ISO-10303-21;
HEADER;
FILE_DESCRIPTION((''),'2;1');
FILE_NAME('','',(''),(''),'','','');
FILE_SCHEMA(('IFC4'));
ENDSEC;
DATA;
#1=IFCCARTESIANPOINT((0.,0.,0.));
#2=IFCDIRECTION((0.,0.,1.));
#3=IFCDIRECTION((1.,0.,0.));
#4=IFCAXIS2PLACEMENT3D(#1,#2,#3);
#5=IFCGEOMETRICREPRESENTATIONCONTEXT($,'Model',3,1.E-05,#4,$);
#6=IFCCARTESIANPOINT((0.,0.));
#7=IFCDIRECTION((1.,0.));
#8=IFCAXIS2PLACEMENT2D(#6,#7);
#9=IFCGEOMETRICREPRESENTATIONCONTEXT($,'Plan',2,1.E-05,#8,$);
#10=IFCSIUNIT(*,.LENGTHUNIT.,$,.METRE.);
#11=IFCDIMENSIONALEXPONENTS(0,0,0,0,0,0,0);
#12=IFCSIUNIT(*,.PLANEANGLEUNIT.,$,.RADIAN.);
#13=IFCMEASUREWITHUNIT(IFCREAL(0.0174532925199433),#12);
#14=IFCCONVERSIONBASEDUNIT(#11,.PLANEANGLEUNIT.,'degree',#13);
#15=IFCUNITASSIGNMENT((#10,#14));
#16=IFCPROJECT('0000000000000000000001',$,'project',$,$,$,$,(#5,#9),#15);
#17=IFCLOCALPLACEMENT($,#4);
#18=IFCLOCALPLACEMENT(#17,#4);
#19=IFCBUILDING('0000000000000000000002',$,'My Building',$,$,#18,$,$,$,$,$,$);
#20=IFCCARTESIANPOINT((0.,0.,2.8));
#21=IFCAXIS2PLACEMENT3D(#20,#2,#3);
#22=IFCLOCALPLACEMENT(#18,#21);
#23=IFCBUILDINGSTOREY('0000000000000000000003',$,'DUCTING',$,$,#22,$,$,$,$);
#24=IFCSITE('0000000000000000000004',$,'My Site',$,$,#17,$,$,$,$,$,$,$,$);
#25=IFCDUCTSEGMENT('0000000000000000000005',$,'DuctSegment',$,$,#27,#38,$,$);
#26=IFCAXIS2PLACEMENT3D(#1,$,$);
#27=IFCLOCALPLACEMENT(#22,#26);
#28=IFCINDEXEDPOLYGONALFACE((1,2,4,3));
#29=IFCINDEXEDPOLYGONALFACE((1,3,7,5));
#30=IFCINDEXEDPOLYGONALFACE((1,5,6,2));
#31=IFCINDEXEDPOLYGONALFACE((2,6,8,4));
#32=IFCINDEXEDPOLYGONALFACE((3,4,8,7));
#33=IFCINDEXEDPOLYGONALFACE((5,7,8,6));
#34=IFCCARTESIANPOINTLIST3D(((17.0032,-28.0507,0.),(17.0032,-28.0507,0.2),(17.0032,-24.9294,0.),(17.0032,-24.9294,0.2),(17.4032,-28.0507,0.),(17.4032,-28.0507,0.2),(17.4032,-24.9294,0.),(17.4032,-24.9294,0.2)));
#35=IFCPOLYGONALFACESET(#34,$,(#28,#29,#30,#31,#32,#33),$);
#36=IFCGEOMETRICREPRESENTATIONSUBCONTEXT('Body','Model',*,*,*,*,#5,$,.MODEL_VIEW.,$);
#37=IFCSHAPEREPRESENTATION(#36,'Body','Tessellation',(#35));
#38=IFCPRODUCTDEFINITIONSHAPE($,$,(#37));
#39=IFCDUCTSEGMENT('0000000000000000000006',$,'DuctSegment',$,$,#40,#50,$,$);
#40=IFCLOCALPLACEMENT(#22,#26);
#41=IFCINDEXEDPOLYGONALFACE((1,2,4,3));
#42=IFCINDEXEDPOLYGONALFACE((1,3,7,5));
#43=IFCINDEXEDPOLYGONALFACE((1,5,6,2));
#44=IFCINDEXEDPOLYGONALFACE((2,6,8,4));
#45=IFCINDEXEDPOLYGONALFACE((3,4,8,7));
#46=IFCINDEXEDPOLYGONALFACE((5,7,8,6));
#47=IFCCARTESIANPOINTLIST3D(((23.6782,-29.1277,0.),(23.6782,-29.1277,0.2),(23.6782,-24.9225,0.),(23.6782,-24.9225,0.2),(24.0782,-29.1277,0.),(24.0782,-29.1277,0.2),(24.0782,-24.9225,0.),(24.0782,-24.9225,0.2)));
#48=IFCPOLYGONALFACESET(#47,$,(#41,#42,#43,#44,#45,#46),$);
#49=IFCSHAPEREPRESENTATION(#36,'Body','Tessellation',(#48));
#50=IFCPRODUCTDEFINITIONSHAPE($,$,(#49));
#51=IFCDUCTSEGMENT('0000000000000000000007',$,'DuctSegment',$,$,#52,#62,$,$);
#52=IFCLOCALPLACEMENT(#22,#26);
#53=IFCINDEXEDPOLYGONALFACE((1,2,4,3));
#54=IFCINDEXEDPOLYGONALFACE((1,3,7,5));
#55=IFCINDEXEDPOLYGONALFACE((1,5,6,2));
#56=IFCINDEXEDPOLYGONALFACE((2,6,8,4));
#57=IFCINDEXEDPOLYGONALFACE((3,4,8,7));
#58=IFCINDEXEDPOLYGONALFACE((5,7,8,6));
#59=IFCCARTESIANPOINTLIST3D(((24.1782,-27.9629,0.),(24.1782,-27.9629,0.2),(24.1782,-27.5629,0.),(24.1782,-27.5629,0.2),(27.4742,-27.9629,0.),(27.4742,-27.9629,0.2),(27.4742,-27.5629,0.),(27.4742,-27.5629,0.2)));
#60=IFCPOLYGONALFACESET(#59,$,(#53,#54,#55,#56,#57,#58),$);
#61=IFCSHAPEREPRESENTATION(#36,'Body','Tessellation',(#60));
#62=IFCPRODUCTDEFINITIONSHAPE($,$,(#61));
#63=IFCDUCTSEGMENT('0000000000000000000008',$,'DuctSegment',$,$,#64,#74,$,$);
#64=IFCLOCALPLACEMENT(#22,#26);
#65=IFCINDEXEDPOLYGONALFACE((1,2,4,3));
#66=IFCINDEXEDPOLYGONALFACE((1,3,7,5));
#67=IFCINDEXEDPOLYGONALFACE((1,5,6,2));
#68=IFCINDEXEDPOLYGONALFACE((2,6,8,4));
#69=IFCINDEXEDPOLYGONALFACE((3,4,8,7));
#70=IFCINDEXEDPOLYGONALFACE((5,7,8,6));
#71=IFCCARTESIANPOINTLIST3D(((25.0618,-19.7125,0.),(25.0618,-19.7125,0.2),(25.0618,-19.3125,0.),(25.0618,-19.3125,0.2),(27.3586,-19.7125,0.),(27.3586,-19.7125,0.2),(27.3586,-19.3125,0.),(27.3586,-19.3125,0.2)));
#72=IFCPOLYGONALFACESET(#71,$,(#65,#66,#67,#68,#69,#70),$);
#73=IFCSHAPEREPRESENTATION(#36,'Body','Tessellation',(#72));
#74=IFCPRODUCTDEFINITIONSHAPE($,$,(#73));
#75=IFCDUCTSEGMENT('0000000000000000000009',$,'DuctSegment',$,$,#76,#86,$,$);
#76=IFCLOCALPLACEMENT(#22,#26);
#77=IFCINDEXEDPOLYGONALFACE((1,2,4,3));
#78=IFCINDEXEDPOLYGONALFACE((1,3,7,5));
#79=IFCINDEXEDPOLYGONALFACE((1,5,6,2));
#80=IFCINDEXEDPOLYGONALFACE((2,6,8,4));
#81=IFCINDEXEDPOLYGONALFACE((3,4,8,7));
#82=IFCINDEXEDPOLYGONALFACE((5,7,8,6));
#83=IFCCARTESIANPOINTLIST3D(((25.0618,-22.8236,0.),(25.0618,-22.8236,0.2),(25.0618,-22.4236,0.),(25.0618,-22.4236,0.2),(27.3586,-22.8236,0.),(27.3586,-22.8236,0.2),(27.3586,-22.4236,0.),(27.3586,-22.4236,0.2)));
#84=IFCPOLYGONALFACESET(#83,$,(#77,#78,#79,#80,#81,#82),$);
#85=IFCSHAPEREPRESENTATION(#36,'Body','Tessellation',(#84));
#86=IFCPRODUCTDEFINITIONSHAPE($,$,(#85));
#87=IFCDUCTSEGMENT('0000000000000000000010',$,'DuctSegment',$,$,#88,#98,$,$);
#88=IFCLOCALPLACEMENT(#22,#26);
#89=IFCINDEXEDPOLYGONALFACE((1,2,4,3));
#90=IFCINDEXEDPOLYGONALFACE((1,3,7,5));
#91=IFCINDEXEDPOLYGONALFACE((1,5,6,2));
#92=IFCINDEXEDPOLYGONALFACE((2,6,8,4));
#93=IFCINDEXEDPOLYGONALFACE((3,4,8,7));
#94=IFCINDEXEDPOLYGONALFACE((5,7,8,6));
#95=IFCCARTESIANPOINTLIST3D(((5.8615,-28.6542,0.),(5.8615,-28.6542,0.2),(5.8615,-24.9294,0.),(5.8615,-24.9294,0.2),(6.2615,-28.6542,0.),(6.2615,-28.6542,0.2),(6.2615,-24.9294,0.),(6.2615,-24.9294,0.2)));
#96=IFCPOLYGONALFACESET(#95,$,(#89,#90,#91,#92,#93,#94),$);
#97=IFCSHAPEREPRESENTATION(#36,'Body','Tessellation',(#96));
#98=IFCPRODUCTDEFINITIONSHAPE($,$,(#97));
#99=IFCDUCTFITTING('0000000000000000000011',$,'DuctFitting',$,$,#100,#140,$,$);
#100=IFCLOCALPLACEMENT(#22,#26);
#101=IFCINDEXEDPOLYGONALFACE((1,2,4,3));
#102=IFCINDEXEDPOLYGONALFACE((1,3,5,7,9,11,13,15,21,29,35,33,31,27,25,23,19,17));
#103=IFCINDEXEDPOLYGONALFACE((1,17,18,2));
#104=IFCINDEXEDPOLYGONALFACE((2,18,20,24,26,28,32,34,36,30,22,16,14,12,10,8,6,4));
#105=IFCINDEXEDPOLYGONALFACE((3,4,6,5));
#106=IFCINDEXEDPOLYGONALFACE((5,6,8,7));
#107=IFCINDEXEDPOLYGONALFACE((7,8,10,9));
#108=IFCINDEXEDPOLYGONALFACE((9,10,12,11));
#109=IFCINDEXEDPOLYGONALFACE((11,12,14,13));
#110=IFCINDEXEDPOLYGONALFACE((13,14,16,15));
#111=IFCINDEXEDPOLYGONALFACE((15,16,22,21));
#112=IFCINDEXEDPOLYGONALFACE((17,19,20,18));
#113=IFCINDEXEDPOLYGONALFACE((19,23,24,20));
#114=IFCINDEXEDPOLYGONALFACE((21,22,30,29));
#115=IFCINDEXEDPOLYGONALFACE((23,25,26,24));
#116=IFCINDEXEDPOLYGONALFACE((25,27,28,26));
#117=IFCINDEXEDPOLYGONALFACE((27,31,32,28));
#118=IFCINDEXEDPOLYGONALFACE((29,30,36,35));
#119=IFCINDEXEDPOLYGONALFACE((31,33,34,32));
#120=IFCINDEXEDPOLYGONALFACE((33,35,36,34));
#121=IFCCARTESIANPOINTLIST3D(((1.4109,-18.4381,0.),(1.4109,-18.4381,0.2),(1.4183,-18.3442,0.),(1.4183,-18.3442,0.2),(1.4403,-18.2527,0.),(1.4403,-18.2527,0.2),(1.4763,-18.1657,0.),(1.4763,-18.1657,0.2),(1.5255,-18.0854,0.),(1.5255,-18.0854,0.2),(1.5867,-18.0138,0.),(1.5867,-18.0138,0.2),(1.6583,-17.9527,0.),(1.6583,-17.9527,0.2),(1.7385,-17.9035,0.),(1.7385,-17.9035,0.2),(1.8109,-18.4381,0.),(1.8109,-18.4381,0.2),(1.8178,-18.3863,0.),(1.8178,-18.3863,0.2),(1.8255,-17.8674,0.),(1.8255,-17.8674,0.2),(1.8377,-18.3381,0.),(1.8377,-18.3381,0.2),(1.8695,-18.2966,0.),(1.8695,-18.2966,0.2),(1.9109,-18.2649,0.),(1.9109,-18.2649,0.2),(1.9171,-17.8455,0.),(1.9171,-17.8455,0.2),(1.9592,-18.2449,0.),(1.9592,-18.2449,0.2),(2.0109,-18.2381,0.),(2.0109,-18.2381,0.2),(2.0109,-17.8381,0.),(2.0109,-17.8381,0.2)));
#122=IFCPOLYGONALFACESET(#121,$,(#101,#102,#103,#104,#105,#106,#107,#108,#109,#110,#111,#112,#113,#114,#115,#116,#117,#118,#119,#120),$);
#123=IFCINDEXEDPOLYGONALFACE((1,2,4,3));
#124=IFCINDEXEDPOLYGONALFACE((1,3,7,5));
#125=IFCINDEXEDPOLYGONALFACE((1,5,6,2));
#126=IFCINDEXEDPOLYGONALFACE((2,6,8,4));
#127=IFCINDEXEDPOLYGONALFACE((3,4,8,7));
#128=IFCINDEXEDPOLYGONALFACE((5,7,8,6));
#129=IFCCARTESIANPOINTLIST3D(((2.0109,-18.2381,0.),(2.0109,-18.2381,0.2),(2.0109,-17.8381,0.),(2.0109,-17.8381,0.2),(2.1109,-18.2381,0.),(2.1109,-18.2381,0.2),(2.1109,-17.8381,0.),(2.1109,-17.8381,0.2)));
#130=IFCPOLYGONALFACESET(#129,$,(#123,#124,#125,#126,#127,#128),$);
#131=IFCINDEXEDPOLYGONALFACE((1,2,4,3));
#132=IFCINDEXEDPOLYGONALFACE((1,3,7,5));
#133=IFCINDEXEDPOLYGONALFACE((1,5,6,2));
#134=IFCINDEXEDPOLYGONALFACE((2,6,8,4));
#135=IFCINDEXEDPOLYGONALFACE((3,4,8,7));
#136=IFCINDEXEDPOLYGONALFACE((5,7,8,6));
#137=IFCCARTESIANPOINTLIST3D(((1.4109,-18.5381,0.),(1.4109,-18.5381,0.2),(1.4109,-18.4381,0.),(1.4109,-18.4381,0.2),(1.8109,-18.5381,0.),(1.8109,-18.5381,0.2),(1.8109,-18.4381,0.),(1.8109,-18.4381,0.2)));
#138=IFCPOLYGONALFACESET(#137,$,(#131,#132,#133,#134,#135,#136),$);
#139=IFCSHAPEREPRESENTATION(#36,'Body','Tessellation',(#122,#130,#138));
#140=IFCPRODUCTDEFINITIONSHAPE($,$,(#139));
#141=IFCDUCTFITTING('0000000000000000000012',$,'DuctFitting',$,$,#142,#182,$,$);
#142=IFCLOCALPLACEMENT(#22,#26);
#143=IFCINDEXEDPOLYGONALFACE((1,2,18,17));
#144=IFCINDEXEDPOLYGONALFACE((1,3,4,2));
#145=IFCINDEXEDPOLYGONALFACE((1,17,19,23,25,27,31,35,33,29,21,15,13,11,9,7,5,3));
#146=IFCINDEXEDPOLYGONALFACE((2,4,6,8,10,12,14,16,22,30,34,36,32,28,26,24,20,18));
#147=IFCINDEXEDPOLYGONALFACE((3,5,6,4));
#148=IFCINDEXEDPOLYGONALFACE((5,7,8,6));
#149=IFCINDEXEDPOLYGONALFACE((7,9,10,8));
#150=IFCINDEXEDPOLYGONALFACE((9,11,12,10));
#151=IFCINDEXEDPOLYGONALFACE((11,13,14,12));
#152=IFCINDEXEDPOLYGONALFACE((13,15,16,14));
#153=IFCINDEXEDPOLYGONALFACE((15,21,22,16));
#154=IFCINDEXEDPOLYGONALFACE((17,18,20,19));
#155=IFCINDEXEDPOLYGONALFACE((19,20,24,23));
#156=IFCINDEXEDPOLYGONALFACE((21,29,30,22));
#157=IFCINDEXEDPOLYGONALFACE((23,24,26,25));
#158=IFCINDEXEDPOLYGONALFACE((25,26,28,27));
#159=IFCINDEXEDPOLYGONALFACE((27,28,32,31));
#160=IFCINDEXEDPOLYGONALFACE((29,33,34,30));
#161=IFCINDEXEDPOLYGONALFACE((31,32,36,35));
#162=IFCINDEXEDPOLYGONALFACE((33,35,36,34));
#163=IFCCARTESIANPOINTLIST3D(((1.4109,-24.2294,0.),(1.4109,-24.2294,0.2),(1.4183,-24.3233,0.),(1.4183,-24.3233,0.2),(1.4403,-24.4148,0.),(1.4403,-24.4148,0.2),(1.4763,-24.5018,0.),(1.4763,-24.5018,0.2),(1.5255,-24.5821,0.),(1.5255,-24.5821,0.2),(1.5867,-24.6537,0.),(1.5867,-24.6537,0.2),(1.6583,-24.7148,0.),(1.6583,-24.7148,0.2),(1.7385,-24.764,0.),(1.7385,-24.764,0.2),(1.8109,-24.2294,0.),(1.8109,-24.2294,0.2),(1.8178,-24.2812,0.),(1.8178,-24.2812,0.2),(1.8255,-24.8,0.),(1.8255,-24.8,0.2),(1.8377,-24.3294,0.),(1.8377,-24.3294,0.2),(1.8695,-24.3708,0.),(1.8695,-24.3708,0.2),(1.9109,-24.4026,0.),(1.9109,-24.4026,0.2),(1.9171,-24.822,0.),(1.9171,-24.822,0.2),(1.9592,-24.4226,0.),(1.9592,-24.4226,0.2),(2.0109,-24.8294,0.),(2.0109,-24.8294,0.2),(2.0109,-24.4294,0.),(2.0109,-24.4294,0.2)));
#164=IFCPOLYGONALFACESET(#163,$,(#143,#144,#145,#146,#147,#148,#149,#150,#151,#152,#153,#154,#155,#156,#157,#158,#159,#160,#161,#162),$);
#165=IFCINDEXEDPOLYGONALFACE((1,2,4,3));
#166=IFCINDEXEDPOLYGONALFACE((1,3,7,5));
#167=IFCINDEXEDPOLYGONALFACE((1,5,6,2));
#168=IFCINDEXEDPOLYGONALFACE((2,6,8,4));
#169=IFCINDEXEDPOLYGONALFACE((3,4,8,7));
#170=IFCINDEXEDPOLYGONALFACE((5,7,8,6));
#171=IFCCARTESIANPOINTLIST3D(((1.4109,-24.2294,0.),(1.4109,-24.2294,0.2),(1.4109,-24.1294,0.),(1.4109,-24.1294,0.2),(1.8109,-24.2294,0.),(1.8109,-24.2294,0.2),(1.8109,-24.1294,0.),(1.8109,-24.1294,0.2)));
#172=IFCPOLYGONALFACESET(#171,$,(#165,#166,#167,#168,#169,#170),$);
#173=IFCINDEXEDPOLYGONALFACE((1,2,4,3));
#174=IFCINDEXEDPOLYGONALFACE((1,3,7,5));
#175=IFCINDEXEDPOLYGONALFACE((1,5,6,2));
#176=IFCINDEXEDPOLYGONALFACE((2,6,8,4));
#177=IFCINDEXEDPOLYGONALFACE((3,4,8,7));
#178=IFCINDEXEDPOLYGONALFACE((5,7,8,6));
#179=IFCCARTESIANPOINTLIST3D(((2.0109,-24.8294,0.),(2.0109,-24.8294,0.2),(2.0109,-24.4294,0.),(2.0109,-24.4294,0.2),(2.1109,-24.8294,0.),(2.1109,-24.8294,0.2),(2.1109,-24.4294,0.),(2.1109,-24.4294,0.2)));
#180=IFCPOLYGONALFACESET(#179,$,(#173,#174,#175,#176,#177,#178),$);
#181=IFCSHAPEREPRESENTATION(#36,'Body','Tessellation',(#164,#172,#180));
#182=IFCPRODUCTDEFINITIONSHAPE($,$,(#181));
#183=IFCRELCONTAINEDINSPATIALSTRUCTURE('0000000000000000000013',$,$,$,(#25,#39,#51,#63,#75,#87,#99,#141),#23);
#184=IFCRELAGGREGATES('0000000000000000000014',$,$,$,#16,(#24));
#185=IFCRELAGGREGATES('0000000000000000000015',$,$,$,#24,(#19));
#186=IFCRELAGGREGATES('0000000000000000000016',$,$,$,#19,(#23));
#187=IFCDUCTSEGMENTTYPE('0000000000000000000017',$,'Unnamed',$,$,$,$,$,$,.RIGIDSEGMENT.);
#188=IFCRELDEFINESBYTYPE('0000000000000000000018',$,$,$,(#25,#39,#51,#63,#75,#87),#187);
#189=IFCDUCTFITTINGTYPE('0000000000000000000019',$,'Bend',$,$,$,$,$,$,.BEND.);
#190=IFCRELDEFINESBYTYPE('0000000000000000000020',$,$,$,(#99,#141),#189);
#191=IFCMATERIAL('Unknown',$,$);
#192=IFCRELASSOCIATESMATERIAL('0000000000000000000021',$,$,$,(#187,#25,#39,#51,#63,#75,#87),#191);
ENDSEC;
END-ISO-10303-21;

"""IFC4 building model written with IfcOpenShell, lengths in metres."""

from ifc_helpers import new_model, entity, si_unit, converted_unit, frame, origin_with_axes, origin_2d_with_axis, place, context, subcontext, project, spatial, line, arc, indexed_curve, rectangle, outline, extrude, source, transform, mapped, material, material_profile, profile_set, profile_usage, type_object, type_shapes, element, save


model = new_model("IFC4")

# Units and contexts
model_context = context("Model", 3, precision=1e-05, world=origin_with_axes())
plan_context = context("Plan", 2, precision=1e-05, world=origin_2d_with_axis())
body_context = subcontext(model_context, "Body", "Model", "MODEL_VIEW")
ifc_project = project(units=[si_unit("LENGTHUNIT", "METRE"), converted_unit("PLANEANGLEUNIT", "degree", entity("IfcReal", 0.0174532925199433), si_unit("PLANEANGLEUNIT", "RADIAN"), dimensions=[0, 0, 0, 0, 0, 0, 0])], contexts=[model_context, plan_context])

# Site, building, storey
site_placement = place(None, origin_with_axes())
site = spatial("IfcSite", under=ifc_project, at=site_placement, Name="My Site")
building_placement = place(site_placement, origin_with_axes())
building = spatial("IfcBuilding", under=site, at=building_placement, Name="My Building")
storey_placement = place(building_placement, frame((0.0, 0.0, 2.8), z_axis=(0.0, 0.0, 1.0), x_axis=(1.0, 0.0, 0.0)))
storey = spatial("IfcBuildingStorey", under=building, at=storey_placement, Name="DUCTING")

# Duct segments
ifc_material = material(Name="Unknown")
ifc_material_profile_1 = material_profile(ifc_material, rectangle(XDim=0.4, YDim=0.2))
ifc_profile_set_1 = profile_set([ifc_material_profile_1])
duct_segment_type = type_object("IfcDuctSegmentType", Name="Unnamed", PredefinedType="RIGIDSEGMENT", material=ifc_profile_set_1)
ifc_profile_usage_1 = profile_usage(ifc_profile_set_1, cardinal=5)
duct_segment_1_placement = place(storey_placement, frame((17.2032, -24.9294, 0.1), z_axis=(0.0, -1.0, 0.0), x_axis=(1.0, 0.0, 0.0)))
element("IfcDuctSegment", 1, at=duct_segment_1_placement, inside=storey, type_object=duct_segment_type, material=ifc_profile_usage_1, Name="DuctSegment", context=body_context, shape_type="SweptSolid", body=[
    extrude(rectangle(XDim=0.4, YDim=0.2), origin_with_axes(), (0.0, 0.0, 1.0), 3.1213),
])
ifc_profile_usage_2 = profile_usage(ifc_profile_set_1, cardinal=5)
duct_segment_2_placement = place(storey_placement, frame((23.8782, -24.9225, 0.1), z_axis=(0.0, -1.0, 0.0), x_axis=(1.0, 0.0, 0.0)))
element("IfcDuctSegment", 2, at=duct_segment_2_placement, inside=storey, type_object=duct_segment_type, material=ifc_profile_usage_2, Name="DuctSegment", context=body_context, shape_type="SweptSolid", body=[
    extrude(rectangle(XDim=0.4, YDim=0.2), origin_with_axes(), (0.0, 0.0, 1.0), 4.2052),
])
ifc_profile_usage_3 = profile_usage(ifc_profile_set_1, cardinal=5)
duct_segment_3_placement = place(storey_placement, frame((24.1782, -27.7629, 0.1), z_axis=(1.0, -0.000001, 0.000001), x_axis=(0.000001, 1.0, 0.0)))
element("IfcDuctSegment", 3, at=duct_segment_3_placement, inside=storey, type_object=duct_segment_type, material=ifc_profile_usage_3, Name="DuctSegment", context=body_context, shape_type="SweptSolid", body=[
    extrude(rectangle(XDim=0.4, YDim=0.2), origin_with_axes(), (0.0, 0.0, 1.0), 3.2961),
])
ifc_profile_usage_4 = profile_usage(ifc_profile_set_1, cardinal=5)
duct_segment_4_placement = place(storey_placement, frame((25.0618, -19.5125, 0.1), z_axis=(1.0, 0.0, 0.0), x_axis=(0.0, 1.0, 0.0)))
element("IfcDuctSegment", 4, at=duct_segment_4_placement, inside=storey, type_object=duct_segment_type, material=ifc_profile_usage_4, Name="DuctSegment", context=body_context, shape_type="SweptSolid", body=[
    extrude(rectangle(XDim=0.4, YDim=0.2), origin_with_axes(), (0.0, 0.0, 1.0), 2.2968),
])
ifc_profile_usage_5 = profile_usage(ifc_profile_set_1, cardinal=5)
duct_segment_5_placement = place(storey_placement, frame((25.0618, -22.6236, 0.1), z_axis=(1.0, 0.0, 0.0), x_axis=(0.0, 1.0, 0.0)))
element("IfcDuctSegment", 5, at=duct_segment_5_placement, inside=storey, type_object=duct_segment_type, material=ifc_profile_usage_5, Name="DuctSegment", context=body_context, shape_type="SweptSolid", body=[
    extrude(rectangle(XDim=0.4, YDim=0.2), origin_with_axes(), (0.0, 0.0, 1.0), 2.2968),
])
ifc_profile_usage_6 = profile_usage(ifc_profile_set_1, cardinal=5)
duct_segment_6_placement = place(storey_placement, frame((6.0615, -24.9294, 0.1), z_axis=(0.0, -1.0, 0.0), x_axis=(1.0, 0.0, 0.0)))
element("IfcDuctSegment", 6, at=duct_segment_6_placement, inside=storey, type_object=duct_segment_type, material=ifc_profile_usage_6, Name="DuctSegment", context=body_context, shape_type="SweptSolid", body=[
    extrude(rectangle(XDim=0.4, YDim=0.2), origin_with_axes(), (0.0, 0.0, 1.0), 3.7248),
])

# Duct fittings
duct_fitting_type_1 = type_object("IfcDuctFittingType", Name="Bend", PredefinedType="BEND")
shared_shape = source(origin_with_axes(), body_context, "Body", "SweptSolid", [
    extrude(outline(indexed_curve([(-0.2, 0.0), (-0.2586, -0.1414), (-0.4, -0.2), (-0.4, -0.6), (0.0243, -0.4243), (0.2, 0.0)], segments=[arc(1, 2, 3), line(3, 4), arc(4, 5, 6), line(6, 1)])), frame((0.0, -0.1, -0.1), z_axis=(0.0, -1.0, 0.0), x_axis=(1.0, 0.0, 0.0)), (0.0, 0.0, -1.0), 0.2),
    extrude(rectangle(XDim=0.4, YDim=0.2), origin_with_axes(), (0.0, 0.0, -1.0), 0.1),
    extrude(rectangle(XDim=0.4, YDim=0.2), frame((-0.4, 0.0, -0.5), z_axis=(-1.0, 0.0, 0.0), x_axis=(0.0, 0.0, -1.0)), (0.0, 0.0, 1.0), 0.1),
])
type_shapes(duct_fitting_type_1, [shared_shape])
for number, where, z_axis, x_axis, name in (
    (7, (2.1109, -18.0381, 0.1), (1.0, 0.0, 0.0), (0.0, 1.0, 0.0), "DuctFitting"),
    (8, (1.6109, -24.1294, 0.1), (0.0, 1.0, 0.0), (-1.0, 0.0, 0.0), "DuctFitting"),
):
    element("IfcDuctFitting", number, at=place(storey_placement, frame(where, z_axis=z_axis, x_axis=x_axis)), inside=storey, type_object=duct_fitting_type_1, Name=name, context=body_context, shape_type="MappedRepresentation", body=[
        mapped(shared_shape, transform((0.0, 0.0, 0.0), x_axis=(1.0, 0.0, 0.0), y_axis=(0.0, 1.0, 0.0), z_axis=(0.0, 0.0, 1.0), scale=1.0)),
    ])

save(model, "model.ifc")
